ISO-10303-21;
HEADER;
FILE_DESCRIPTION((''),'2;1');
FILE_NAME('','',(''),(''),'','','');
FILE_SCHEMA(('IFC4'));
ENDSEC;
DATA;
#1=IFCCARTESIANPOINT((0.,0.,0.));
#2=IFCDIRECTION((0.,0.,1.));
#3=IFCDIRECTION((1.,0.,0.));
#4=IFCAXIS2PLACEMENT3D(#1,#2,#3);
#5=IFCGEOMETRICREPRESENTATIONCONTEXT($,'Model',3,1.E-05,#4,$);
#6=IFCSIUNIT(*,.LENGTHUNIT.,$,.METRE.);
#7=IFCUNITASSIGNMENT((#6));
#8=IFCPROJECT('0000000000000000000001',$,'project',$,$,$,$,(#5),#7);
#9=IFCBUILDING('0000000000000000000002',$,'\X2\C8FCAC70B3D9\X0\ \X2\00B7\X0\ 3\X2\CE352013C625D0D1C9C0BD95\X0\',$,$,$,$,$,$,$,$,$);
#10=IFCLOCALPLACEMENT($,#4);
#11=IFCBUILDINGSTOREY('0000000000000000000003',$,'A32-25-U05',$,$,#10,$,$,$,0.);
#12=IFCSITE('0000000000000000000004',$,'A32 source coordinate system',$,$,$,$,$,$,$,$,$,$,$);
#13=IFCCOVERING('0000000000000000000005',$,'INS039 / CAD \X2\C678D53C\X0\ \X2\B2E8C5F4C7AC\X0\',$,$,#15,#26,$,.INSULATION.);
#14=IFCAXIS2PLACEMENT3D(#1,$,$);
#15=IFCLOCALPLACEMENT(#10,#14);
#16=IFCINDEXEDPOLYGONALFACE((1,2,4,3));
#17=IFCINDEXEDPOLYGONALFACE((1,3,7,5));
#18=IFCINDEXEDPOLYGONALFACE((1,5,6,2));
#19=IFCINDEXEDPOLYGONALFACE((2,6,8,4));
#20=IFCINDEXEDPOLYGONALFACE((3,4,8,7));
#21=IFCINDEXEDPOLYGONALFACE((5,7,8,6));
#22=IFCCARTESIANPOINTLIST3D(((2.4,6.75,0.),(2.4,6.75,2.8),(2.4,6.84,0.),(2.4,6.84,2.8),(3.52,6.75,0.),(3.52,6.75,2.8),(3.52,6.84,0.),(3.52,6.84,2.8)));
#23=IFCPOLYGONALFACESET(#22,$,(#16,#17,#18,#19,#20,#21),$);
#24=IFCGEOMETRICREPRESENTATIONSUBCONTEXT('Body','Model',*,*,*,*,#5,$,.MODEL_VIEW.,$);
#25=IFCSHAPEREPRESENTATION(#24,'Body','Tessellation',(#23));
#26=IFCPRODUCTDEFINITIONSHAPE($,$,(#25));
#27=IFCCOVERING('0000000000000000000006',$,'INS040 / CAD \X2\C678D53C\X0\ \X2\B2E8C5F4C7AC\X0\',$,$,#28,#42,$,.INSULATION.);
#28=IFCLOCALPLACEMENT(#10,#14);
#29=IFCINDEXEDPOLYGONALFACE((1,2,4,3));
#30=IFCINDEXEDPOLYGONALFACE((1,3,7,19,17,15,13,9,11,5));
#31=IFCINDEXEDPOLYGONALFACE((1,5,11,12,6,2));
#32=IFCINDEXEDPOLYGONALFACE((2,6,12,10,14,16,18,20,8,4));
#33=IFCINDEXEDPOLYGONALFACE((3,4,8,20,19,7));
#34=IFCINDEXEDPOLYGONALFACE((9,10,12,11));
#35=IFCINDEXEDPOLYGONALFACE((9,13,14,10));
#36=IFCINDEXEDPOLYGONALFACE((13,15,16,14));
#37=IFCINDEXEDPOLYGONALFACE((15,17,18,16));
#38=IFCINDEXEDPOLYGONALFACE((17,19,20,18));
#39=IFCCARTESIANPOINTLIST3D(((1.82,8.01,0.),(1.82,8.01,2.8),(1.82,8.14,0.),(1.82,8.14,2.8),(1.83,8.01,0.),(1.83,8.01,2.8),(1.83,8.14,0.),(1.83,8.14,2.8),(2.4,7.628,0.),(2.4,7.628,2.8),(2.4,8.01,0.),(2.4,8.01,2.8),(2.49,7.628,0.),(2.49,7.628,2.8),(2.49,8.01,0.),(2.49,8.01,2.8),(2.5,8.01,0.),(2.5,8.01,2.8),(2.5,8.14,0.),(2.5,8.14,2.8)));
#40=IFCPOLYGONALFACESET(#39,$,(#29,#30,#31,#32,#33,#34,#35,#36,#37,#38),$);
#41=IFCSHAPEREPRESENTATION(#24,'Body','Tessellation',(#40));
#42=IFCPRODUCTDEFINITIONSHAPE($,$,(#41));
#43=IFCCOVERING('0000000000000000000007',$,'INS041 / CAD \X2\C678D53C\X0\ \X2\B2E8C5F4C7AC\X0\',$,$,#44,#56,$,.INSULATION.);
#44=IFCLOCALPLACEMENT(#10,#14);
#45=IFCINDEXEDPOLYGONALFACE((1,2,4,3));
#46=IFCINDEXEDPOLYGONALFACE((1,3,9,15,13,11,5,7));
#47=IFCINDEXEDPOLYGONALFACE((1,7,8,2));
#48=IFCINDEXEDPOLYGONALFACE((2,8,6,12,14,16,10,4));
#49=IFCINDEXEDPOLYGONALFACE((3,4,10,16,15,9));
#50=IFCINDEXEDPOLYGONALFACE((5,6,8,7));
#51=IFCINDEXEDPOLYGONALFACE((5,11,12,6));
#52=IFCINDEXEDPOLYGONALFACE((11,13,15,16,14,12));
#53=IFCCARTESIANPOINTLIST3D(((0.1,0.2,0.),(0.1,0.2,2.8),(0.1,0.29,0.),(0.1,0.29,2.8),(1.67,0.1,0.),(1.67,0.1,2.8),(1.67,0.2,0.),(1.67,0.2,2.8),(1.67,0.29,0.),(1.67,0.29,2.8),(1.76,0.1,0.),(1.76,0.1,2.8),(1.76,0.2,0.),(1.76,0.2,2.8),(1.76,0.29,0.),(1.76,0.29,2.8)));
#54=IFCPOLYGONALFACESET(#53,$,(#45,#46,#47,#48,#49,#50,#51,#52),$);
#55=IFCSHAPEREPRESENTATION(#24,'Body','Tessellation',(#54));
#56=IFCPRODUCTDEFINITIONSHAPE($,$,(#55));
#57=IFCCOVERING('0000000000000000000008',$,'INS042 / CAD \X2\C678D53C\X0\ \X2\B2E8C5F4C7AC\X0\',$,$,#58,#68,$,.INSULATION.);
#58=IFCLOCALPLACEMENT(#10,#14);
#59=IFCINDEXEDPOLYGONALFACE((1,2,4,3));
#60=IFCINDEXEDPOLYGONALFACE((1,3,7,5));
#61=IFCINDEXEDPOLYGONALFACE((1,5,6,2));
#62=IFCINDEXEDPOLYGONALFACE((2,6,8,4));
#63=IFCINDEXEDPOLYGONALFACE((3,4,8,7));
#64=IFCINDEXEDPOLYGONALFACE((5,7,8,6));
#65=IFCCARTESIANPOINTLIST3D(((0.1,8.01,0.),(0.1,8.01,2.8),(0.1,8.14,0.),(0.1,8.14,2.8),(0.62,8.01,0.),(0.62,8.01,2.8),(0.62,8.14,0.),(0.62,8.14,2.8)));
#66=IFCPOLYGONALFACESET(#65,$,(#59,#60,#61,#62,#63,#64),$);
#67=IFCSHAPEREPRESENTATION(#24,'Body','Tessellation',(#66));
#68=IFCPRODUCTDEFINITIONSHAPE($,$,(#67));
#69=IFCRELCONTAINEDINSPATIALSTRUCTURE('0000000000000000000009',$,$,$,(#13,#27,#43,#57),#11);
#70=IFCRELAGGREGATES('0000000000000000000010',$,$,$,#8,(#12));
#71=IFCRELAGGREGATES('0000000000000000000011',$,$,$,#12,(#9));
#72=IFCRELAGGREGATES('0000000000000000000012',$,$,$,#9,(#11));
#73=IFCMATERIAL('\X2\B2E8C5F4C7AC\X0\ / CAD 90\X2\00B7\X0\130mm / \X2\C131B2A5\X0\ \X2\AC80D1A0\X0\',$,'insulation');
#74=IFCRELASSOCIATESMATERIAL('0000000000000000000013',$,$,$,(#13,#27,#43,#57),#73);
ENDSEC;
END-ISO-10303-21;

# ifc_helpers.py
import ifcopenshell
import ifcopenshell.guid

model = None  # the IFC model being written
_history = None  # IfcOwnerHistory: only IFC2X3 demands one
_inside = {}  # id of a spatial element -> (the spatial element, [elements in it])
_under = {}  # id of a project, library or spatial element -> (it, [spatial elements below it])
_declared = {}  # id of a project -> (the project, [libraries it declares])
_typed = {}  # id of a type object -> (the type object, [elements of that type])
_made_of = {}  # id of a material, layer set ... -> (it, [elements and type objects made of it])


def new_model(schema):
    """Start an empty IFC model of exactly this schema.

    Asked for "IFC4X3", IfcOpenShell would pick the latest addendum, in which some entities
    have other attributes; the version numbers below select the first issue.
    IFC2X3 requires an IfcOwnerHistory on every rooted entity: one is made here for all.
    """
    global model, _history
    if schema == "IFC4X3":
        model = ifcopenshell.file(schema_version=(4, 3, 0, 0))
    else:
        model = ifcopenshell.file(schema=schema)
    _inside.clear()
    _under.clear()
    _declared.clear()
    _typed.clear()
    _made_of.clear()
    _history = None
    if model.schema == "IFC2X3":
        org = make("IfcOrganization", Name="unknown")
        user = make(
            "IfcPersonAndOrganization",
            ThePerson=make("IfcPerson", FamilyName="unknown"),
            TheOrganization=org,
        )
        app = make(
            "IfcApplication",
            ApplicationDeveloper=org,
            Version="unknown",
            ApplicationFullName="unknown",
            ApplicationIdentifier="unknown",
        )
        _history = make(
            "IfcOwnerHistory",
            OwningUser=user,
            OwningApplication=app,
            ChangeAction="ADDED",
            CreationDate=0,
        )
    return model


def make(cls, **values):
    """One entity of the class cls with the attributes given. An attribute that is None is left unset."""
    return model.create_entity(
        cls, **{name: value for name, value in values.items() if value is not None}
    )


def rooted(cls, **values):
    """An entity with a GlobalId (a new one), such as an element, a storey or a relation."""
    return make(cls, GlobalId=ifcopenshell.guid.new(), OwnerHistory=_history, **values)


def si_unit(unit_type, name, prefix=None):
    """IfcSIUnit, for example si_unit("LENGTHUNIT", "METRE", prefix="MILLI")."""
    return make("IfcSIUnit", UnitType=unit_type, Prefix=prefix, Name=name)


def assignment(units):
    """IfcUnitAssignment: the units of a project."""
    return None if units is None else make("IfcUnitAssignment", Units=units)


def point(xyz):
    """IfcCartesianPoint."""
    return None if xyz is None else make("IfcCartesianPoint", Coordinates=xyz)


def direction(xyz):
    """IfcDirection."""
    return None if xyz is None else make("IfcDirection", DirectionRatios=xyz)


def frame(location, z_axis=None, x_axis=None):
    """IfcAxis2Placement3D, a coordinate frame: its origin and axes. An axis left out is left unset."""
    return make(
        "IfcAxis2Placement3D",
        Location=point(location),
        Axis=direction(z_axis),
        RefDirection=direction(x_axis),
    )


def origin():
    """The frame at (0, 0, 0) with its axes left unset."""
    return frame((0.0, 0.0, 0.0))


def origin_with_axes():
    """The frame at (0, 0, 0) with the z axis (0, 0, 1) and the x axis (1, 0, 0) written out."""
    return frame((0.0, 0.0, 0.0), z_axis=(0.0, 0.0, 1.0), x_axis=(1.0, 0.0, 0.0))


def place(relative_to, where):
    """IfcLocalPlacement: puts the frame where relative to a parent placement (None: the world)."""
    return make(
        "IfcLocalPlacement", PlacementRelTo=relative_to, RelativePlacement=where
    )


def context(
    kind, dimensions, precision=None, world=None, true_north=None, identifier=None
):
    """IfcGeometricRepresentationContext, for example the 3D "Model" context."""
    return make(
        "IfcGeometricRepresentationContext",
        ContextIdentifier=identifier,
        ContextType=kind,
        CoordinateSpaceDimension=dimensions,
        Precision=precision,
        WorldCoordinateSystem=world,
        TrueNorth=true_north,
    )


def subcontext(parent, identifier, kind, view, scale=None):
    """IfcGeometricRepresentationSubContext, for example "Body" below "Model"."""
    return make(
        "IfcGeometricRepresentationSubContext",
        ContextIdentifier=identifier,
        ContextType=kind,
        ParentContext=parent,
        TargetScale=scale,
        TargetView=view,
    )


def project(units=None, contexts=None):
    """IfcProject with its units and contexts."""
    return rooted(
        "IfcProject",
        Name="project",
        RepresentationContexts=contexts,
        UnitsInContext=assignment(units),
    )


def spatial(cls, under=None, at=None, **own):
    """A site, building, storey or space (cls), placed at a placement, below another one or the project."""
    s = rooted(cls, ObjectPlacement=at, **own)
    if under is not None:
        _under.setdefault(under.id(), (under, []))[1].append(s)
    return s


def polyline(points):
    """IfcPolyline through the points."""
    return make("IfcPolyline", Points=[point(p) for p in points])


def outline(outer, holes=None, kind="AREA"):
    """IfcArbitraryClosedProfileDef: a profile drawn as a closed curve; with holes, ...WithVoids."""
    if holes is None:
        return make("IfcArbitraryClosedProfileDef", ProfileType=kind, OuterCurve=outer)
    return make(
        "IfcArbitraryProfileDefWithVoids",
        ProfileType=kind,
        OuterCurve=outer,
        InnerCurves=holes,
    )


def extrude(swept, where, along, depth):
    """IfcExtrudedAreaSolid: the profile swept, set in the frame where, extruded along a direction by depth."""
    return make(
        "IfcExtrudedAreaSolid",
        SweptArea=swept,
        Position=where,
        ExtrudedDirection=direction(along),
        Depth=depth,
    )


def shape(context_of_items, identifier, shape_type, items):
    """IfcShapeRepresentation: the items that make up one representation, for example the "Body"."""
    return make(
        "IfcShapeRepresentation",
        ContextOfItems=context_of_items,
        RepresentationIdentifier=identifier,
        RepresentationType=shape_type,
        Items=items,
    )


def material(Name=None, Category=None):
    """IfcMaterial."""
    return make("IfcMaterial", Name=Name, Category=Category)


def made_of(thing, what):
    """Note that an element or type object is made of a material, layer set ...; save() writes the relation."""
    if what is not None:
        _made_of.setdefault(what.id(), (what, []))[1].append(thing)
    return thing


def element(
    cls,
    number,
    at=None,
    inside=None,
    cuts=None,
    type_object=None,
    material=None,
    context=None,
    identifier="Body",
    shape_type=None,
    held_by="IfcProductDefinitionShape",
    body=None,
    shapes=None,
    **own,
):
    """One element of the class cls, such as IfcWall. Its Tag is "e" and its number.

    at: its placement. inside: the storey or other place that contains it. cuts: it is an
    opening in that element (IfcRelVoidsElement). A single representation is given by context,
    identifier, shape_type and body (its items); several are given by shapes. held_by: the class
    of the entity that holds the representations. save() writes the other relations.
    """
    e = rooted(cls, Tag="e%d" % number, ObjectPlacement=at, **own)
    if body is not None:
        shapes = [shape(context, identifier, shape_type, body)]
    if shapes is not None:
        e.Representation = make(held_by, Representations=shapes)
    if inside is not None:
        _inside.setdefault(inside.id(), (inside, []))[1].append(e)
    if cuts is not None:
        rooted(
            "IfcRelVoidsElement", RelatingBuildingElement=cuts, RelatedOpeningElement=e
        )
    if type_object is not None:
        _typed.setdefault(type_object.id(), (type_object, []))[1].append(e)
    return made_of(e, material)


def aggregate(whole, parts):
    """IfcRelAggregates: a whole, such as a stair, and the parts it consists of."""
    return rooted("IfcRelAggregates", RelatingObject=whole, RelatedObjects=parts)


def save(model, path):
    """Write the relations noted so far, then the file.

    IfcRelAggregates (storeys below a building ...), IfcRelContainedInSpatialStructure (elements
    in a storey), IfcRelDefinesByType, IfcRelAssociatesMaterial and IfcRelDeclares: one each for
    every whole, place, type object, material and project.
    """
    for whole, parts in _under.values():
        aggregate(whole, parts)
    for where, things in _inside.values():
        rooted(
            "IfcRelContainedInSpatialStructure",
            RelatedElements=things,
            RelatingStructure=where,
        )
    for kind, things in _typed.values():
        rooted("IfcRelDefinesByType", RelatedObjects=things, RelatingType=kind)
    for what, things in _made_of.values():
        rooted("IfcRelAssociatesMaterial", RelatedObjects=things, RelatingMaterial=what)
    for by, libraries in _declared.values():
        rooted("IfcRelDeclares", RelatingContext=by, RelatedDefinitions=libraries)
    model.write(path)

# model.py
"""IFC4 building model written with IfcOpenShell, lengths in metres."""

from ifc_helpers import new_model, si_unit, origin, origin_with_axes, place, context, subcontext, project, spatial, polyline, outline, extrude, material, element, save


model = new_model("IFC4")

# Units and contexts
model_context = context("Model", 3, precision=1e-05, world=origin_with_axes())
body_context = subcontext(model_context, "Body", "Model", "MODEL_VIEW")
ifc_project = project(units=[si_unit("LENGTHUNIT", "METRE")], contexts=[model_context])

# Site, building, storey
storey_placement = place(None, origin_with_axes())
site = spatial("IfcSite", under=ifc_project, Name="A32 source coordinate system")
building = spatial("IfcBuilding", under=site, Name="주거동 · 3층–옥탑지붕")
storey = spatial("IfcBuildingStorey", under=building, at=storey_placement, Name="A32-25-U05", Elevation=0.0)

# Coverings
ifc_material = material(Name="단열재 / CAD 90·130mm / 성능 검토", Category="insulation")
covering_1_placement = place(storey_placement, origin_with_axes())
element("IfcCovering", 1, at=covering_1_placement, inside=storey, material=ifc_material, Name="INS039 / CAD 외피 단열재", PredefinedType="INSULATION", context=body_context, shape_type="SweptSolid", body=[
    extrude(outline(polyline([(2.4, 6.75), (2.4, 6.84), (3.52, 6.84), (3.52, 6.75), (2.4, 6.75)])), origin(), (0.0, 0.0, 1.0), 2.8),
])
covering_2_placement = place(storey_placement, origin_with_axes())
element("IfcCovering", 2, at=covering_2_placement, inside=storey, material=ifc_material, Name="INS040 / CAD 외피 단열재", PredefinedType="INSULATION", context=body_context, shape_type="SweptSolid", body=[
    extrude(outline(polyline([(2.4, 7.628), (2.4, 8.01), (1.83, 8.01), (1.82, 8.01), (1.82, 8.14), (1.83, 8.14), (2.5, 8.14), (2.5, 8.01), (2.49, 8.01), (2.49, 7.628), (2.4, 7.628)])), origin(), (0.0, 0.0, 1.0), 2.8),
])
covering_3_placement = place(storey_placement, origin_with_axes())
element("IfcCovering", 3, at=covering_3_placement, inside=storey, material=ifc_material, Name="INS041 / CAD 외피 단열재", PredefinedType="INSULATION", context=body_context, shape_type="SweptSolid", body=[
    extrude(outline(polyline([(1.67, 0.2), (0.1, 0.2), (0.1, 0.29), (1.67, 0.29), (1.76, 0.29), (1.76, 0.2), (1.76, 0.1), (1.67, 0.1), (1.67, 0.2)])), origin(), (0.0, 0.0, 1.0), 2.8),
])
covering_4_placement = place(storey_placement, origin_with_axes())
element("IfcCovering", 4, at=covering_4_placement, inside=storey, material=ifc_material, Name="INS042 / CAD 외피 단열재", PredefinedType="INSULATION", context=body_context, shape_type="SweptSolid", body=[
    extrude(outline(polyline([(0.62, 8.14), (0.62, 8.01), (0.1, 8.01), (0.1, 8.14), (0.62, 8.14)])), origin(), (0.0, 0.0, 1.0), 2.8),
])

save(model, "model.ifc")
